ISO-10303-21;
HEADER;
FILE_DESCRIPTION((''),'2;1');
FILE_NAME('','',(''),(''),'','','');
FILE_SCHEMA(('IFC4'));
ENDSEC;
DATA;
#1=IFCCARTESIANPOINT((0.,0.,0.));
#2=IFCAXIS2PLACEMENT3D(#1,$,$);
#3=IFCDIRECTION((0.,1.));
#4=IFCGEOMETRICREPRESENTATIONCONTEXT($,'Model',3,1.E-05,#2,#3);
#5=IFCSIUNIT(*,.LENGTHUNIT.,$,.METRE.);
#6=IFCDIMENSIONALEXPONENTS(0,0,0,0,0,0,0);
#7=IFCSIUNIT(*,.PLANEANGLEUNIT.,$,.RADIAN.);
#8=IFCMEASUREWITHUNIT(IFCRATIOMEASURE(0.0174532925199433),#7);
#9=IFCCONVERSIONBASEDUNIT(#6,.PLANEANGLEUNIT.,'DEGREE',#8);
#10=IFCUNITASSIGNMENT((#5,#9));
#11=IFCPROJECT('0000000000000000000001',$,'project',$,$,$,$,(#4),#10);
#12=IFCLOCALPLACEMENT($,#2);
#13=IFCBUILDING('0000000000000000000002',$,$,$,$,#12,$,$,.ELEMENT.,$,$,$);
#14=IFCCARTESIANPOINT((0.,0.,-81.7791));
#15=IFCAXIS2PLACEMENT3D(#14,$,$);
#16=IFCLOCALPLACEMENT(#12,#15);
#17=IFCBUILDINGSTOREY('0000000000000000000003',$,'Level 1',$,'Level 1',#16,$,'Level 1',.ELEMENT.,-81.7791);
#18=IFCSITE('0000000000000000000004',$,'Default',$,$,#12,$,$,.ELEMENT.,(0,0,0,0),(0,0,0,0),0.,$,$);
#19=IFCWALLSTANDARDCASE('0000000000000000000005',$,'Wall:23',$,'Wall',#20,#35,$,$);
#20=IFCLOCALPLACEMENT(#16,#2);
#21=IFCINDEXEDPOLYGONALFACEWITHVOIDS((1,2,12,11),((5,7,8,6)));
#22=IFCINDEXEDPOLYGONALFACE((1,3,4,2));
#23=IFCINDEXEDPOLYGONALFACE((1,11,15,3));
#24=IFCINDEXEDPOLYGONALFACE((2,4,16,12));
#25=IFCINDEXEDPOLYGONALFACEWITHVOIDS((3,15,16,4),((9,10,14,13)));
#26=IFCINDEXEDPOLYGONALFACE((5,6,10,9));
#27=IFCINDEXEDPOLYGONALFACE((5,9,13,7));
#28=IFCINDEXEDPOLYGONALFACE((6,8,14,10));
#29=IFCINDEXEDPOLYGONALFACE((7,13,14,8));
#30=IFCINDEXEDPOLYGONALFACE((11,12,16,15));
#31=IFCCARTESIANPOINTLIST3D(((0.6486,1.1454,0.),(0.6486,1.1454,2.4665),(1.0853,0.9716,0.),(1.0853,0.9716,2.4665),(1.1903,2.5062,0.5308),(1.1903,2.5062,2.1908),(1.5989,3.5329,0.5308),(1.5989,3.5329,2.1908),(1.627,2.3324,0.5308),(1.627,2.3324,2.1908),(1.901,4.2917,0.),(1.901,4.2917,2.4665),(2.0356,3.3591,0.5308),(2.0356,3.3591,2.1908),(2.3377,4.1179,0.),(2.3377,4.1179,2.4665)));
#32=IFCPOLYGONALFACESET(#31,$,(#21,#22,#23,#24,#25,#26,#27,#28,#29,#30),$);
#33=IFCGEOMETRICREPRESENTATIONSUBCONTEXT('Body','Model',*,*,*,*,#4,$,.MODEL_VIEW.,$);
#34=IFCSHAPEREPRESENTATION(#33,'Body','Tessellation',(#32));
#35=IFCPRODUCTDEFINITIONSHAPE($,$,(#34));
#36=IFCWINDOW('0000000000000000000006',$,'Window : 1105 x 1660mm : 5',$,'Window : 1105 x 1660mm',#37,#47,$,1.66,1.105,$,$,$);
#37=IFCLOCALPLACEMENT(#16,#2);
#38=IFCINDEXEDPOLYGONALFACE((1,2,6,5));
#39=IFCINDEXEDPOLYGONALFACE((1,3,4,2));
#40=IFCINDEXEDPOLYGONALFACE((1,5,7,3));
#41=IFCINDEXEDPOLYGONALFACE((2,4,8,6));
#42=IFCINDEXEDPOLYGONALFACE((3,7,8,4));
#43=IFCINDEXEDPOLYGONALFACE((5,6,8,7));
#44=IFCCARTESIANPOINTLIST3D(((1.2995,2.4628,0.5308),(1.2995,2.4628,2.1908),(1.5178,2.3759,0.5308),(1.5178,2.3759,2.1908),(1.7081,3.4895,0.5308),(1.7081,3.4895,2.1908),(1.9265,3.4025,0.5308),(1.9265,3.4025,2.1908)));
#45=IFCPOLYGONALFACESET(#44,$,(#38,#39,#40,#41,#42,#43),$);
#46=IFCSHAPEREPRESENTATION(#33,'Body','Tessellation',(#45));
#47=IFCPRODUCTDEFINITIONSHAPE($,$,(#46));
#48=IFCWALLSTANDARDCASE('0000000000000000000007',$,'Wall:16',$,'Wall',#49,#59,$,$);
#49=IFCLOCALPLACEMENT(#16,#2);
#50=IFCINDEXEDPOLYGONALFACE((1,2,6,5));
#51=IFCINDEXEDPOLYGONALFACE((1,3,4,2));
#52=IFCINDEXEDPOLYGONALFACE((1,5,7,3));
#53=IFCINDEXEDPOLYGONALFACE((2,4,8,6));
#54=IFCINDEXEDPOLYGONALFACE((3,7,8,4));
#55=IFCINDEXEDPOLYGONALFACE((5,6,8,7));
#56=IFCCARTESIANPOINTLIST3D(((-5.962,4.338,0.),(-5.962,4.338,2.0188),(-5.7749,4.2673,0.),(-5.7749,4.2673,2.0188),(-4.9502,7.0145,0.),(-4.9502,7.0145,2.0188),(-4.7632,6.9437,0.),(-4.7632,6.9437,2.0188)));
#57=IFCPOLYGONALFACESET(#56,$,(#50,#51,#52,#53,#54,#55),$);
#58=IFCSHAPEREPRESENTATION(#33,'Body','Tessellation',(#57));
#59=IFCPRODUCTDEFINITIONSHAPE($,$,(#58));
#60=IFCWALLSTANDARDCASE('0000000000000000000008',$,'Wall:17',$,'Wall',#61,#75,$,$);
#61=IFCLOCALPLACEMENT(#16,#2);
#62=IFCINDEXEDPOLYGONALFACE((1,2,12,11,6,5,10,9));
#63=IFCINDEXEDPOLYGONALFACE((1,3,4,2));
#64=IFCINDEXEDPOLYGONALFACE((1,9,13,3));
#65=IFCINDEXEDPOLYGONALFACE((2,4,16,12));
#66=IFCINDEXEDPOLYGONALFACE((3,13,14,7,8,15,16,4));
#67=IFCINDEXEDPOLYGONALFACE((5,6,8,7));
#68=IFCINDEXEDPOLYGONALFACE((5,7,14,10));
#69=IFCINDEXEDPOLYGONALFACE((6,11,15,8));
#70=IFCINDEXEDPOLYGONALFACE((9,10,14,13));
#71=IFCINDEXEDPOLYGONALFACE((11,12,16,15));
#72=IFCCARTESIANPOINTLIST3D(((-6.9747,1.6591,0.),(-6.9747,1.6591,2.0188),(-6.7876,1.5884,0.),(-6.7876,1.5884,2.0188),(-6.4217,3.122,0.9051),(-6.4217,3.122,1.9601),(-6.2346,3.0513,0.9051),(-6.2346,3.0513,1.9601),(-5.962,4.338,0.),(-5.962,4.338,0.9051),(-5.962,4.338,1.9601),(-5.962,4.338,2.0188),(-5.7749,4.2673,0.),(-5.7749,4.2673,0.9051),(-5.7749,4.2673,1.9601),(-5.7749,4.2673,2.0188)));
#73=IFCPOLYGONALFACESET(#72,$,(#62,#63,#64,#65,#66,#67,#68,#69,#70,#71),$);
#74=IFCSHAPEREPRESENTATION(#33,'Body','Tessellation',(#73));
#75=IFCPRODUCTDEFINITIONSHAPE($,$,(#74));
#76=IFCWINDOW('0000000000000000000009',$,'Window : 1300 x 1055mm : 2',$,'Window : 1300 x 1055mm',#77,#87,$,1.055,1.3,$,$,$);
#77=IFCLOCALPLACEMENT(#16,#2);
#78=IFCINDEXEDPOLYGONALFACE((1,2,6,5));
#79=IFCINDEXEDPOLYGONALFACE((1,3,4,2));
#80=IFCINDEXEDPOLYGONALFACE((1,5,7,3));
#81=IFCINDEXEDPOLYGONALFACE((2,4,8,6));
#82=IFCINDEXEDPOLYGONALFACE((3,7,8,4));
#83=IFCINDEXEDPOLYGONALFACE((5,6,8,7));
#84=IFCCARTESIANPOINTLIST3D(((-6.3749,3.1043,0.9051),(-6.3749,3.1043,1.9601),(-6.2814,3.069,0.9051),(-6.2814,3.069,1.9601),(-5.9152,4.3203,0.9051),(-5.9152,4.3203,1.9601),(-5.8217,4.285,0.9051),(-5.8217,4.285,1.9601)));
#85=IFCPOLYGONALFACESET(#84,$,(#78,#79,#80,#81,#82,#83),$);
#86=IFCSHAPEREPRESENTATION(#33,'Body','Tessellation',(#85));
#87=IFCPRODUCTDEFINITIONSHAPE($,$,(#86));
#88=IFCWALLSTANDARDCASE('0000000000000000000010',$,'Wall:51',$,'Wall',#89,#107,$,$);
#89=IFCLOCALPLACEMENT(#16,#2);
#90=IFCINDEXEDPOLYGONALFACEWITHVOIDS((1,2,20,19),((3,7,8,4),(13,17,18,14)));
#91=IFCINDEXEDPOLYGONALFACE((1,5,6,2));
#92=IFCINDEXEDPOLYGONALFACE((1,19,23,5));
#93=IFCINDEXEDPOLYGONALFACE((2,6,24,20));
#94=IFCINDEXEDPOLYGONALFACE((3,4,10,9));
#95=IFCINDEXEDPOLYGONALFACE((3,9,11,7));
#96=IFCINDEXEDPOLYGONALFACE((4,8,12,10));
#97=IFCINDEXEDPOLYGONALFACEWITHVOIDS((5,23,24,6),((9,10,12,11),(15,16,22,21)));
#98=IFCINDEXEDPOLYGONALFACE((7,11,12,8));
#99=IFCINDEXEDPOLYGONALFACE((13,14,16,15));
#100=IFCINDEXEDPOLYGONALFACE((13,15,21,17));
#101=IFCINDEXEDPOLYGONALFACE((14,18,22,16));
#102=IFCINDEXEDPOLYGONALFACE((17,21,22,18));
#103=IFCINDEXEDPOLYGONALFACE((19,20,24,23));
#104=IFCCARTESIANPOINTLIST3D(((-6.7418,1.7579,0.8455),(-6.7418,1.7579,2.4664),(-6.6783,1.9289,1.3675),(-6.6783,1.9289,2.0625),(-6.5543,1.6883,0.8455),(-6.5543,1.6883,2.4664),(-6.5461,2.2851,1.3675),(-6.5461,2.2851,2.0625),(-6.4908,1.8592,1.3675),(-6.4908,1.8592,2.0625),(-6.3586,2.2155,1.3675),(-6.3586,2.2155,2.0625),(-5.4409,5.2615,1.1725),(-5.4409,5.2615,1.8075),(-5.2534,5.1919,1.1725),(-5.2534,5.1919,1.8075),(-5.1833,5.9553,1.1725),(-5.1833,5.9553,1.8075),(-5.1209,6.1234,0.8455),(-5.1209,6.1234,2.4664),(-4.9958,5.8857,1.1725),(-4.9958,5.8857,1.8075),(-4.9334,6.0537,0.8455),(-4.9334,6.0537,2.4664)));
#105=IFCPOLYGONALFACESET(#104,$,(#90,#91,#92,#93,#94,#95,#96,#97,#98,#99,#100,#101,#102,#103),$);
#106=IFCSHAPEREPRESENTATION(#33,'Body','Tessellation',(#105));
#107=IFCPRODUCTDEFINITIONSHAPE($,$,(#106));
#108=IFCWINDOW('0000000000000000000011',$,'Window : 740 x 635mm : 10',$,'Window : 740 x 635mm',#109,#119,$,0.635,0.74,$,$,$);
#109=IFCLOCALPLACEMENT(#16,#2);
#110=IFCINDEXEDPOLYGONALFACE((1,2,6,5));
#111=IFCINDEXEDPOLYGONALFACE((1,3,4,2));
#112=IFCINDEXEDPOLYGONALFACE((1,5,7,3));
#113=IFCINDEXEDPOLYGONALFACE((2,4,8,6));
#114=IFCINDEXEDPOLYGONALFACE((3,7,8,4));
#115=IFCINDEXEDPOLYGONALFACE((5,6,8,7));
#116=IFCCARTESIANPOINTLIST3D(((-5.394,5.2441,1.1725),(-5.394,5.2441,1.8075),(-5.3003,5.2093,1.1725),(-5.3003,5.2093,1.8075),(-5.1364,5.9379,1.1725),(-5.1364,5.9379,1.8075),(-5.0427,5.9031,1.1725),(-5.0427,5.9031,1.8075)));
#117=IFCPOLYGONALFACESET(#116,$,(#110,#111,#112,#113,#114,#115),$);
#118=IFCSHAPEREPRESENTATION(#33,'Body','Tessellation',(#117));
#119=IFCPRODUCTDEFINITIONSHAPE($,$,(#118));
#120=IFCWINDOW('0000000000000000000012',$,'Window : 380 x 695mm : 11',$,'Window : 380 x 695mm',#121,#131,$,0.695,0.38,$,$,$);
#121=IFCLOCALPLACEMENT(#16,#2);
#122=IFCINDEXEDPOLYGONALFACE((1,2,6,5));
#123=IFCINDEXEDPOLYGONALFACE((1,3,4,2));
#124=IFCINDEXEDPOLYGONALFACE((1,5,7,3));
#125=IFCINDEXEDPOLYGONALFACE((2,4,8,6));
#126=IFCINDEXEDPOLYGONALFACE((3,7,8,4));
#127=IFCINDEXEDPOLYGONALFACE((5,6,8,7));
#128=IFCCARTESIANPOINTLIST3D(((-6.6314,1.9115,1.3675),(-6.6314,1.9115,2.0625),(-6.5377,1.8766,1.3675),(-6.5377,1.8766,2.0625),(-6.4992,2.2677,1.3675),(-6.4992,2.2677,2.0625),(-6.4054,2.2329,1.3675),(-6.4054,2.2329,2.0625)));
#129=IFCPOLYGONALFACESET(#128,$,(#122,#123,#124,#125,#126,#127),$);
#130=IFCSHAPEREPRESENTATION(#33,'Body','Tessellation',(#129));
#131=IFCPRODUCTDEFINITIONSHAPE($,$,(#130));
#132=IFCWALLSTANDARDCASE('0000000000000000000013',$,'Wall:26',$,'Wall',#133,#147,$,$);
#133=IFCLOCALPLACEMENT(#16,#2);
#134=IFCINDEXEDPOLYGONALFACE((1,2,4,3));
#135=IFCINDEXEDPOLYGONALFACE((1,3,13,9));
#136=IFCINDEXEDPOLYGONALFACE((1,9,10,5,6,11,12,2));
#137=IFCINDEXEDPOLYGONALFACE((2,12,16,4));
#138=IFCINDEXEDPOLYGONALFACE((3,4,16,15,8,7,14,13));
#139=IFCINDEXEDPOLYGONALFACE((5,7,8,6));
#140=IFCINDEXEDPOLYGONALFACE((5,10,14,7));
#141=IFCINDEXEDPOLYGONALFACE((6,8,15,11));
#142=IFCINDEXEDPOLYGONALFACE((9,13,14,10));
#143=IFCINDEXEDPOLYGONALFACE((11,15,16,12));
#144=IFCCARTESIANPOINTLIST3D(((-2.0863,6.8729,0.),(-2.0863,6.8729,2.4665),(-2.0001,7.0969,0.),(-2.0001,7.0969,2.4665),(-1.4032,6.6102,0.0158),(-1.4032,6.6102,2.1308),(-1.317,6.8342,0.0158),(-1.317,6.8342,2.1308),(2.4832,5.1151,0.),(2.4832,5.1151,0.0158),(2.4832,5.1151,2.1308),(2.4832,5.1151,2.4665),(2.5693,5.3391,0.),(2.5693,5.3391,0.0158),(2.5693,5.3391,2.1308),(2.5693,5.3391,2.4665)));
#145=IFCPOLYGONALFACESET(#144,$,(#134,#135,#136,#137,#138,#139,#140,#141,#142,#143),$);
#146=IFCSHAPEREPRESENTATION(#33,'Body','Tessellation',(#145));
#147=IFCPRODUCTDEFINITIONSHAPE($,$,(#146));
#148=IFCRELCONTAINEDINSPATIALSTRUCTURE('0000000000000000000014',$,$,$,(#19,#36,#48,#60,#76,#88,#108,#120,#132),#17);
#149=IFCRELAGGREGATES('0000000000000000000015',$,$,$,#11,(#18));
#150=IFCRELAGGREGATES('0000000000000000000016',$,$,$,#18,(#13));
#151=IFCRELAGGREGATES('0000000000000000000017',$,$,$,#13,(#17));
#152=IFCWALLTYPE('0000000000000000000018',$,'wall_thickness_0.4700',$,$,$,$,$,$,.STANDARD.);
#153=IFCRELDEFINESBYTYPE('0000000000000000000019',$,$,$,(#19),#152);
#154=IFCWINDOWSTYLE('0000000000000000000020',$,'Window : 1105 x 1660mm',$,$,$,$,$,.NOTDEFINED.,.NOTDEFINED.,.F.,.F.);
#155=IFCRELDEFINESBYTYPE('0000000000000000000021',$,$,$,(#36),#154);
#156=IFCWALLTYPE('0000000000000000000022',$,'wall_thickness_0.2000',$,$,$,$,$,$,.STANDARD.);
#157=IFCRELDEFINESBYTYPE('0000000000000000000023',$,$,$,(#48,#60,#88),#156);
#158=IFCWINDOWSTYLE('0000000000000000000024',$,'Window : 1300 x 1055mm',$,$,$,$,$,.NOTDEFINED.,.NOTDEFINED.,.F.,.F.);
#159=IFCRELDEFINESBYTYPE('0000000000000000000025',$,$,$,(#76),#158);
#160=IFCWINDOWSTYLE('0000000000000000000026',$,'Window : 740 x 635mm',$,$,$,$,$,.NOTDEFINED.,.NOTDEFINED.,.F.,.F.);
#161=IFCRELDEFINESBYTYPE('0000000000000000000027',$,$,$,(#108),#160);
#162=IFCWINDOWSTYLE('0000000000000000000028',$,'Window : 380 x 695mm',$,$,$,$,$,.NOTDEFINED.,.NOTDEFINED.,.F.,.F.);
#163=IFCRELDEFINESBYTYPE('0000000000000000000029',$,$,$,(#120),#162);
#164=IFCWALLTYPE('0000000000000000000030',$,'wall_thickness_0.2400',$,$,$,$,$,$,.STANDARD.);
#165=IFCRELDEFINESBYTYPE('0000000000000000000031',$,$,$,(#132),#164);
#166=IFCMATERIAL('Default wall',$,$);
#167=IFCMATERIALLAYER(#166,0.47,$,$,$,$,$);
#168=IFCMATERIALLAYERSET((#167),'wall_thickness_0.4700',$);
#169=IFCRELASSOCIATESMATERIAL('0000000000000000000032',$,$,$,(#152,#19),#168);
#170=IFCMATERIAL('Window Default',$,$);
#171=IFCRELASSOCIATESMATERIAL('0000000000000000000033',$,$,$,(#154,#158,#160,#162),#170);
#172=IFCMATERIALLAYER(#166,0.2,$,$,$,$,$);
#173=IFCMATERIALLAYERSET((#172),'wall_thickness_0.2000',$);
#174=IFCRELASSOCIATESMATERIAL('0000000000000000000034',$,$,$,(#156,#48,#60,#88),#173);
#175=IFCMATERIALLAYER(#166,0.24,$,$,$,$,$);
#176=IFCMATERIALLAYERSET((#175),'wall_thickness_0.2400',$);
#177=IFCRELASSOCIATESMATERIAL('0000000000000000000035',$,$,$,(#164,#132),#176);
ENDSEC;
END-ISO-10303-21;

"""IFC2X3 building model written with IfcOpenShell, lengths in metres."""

from ifc_helpers import new_model, entity, si_unit, converted_unit, direction, frame, frame_2d, origin, origin_2d_with_axis, place, context, subcontext, project, spatial, polyline, rectangle, outline, extrude, source, transform, mapped, material, layer, layer_set, layer_usage, type_object, type_shapes, element, fill, save


model = new_model("IFC2X3")

# Units and contexts
model_context = context("Model", 3, precision=1e-05, world=origin(), true_north=direction((0.0, 1.0)))
body_context = subcontext(model_context, "Body", "Model", "MODEL_VIEW")
ifc_project = project(units=[si_unit("LENGTHUNIT", "METRE"), converted_unit("PLANEANGLEUNIT", "DEGREE", entity("IfcRatioMeasure", 0.0174532925199433), si_unit("PLANEANGLEUNIT", "RADIAN"), dimensions=[0, 0, 0, 0, 0, 0, 0])], contexts=[model_context])

# Site, building, storey
placement_1 = place(None, origin())
site = spatial("IfcSite", under=ifc_project, at=placement_1, Name="Default", CompositionType="ELEMENT", RefLatitude=(0, 0, 0, 0), RefLongitude=(0, 0, 0, 0), RefElevation=0.0)
building = spatial("IfcBuilding", under=site, at=placement_1, CompositionType="ELEMENT")
storey_placement = place(placement_1, frame((0.0, 0.0, -81.7791)))
storey = spatial("IfcBuildingStorey", under=building, at=storey_placement, Name="Level 1", ObjectType="Level 1", LongName="Level 1", CompositionType="ELEMENT", Elevation=-81.7791)

# Shared definitions
ifc_material_1 = material(Name="Default wall")

# Shared definitions
ifc_layer_1 = layer(ifc_material_1, 0.47)
ifc_layer_set_1 = layer_set([ifc_layer_1], Name="wall_thickness_0.4700")
ifc_layer_usage_1 = layer_usage(ifc_layer_set_1, "AXIS2", "POSITIVE", -0.235)
wall_type_1 = type_object("IfcWallType", Name="wall_thickness_0.4700", PredefinedType="STANDARD", material=ifc_layer_set_1)

# Wall, opening, window
wall_1_placement = place(storey_placement, frame((2.1193, 4.2048, 0.0), z_axis=(0.0, 0.0, 1.0), x_axis=(-0.36982, -0.929103, 0.0)))
wall_1 = element("IfcWallStandardCase", 1, at=wall_1_placement, inside=storey, type_object=wall_type_1, material=ifc_layer_usage_1, Name="Wall:23", ObjectType="Wall", context=body_context, shape_type="SweptSolid", body=[
    extrude(outline(polyline([(3.3864, -0.235), (3.3864, 0.235), (0.0, 0.235), (0.0, -0.235), (3.3864, -0.235)])), origin(), (0.0, 0.0, 1.0), 2.4665),
])
opening_1_placement = place(wall_1_placement, frame((0.8167, -0.235, 0.5308)))
opening_1 = element("IfcOpeningElement", 2, at=opening_1_placement, cuts=wall_1, ObjectType="Opening", context=body_context, shape_type="SweptSolid", body=[
    extrude(rectangle(XDim=1.105, YDim=1.66, at=frame_2d((0.83, 0.5525), x_axis=(0.0, 1.0))), frame((0.0, 0.0, 0.0), z_axis=(0.0, 1.0, 0.0), x_axis=(0.0, 0.0, 1.0)), (0.0, 0.0, 1.0), 0.47),
])
ifc_material_2 = material(Name="Window Default")
window_style_1 = type_object("IfcWindowStyle", Name="Window : 1105 x 1660mm", ConstructionType="NOTDEFINED", OperationType="NOTDEFINED", ParameterTakesPrecedence=False, Sizeable=False, material=ifc_material_2)
shared_shape_1 = source(origin(), body_context, "Body", "SweptSolid", [
    extrude(rectangle(XDim=0.235, YDim=1.105, at=origin_2d_with_axis()), frame((0.5525, 0.235, 0.0), z_axis=(0.0, 0.0, 1.0), x_axis=(0.0, 1.0, 0.0)), (0.0, 0.0, 1.0), 1.66),
])
type_shapes(window_style_1, [shared_shape_1])
window_1_placement = place(opening_1_placement, origin())
window_1 = element("IfcWindow", 3, at=window_1_placement, inside=storey, type_object=window_style_1, Name="Window : 1105 x 1660mm : 5", ObjectType="Window : 1105 x 1660mm", OverallHeight=1.66, OverallWidth=1.105, context=body_context, shape_type="MappedRepresentation", body=[
    mapped(shared_shape_1, transform((0.0, 0.0, 0.0), scale=1.0)),
])
fill(opening_1, window_1)

# Wall
ifc_layer_2 = layer(ifc_material_1, 0.2)
ifc_layer_set_2 = layer_set([ifc_layer_2], Name="wall_thickness_0.2000")
ifc_layer_usage_2 = layer_usage(ifc_layer_set_2, "AXIS2", "POSITIVE", -0.1)
wall_type_2 = type_object("IfcWallType", Name="wall_thickness_0.2000", PredefinedType="STANDARD", material=ifc_layer_set_2)
wall_2_placement = place(storey_placement, frame((-4.8567, 6.9791, 0.0), z_axis=(0.0, 0.0, 1.0), x_axis=(-0.353606, -0.935394, 0.0)))
element("IfcWallStandardCase", 4, at=wall_2_placement, inside=storey, type_object=wall_type_2, material=ifc_layer_usage_2, Name="Wall:16", ObjectType="Wall", context=body_context, shape_type="SweptSolid", body=[
    extrude(outline(polyline([(2.8613, -0.1), (2.8613, 0.1), (0.0, 0.1), (0.0, -0.1), (2.8613, -0.1)])), origin(), (0.0, 0.0, 1.0), 2.0188),
])

# Wall, opening, window
wall_3_placement = place(storey_placement, frame((-5.8685, 4.3027, 0.0), z_axis=(0.0, 0.0, 1.0), x_axis=(-0.353606, -0.935394, 0.0)))
wall_3 = element("IfcWallStandardCase", 5, at=wall_3_placement, inside=storey, type_object=wall_type_2, material=ifc_layer_usage_2, Name="Wall:17", ObjectType="Wall", context=body_context, shape_type="SweptSolid", body=[
    extrude(outline(polyline([(2.8639, -0.1), (2.8639, 0.1), (0.0, 0.1), (0.0, -0.1), (2.8639, -0.1)])), origin(), (0.0, 0.0, 1.0), 2.0188),
])
opening_2_placement = place(wall_3_placement, frame((0.0, -0.1, 0.9051)))
opening_2 = element("IfcOpeningElement", 6, at=opening_2_placement, cuts=wall_3, ObjectType="Opening", context=body_context, shape_type="SweptSolid", body=[
    extrude(rectangle(XDim=1.3, YDim=1.055, at=frame_2d((0.5275, 0.65), x_axis=(0.0, 1.0))), frame((0.0, 0.0, 0.0), z_axis=(0.0, 1.0, 0.0), x_axis=(0.0, 0.0, 1.0)), (0.0, 0.0, 1.0), 0.2),
])
window_style_2 = type_object("IfcWindowStyle", Name="Window : 1300 x 1055mm", ConstructionType="NOTDEFINED", OperationType="NOTDEFINED", ParameterTakesPrecedence=False, Sizeable=False, material=ifc_material_2)
shared_shape_2 = source(origin(), body_context, "Body", "SweptSolid", [
    extrude(rectangle(XDim=0.1, YDim=1.3, at=origin_2d_with_axis()), frame((0.65, 0.1, 0.0), z_axis=(0.0, 0.0, 1.0), x_axis=(0.0, 1.0, 0.0)), (0.0, 0.0, 1.0), 1.055),
])
type_shapes(window_style_2, [shared_shape_2])
window_2_placement = place(opening_2_placement, origin())
window_2 = element("IfcWindow", 7, at=window_2_placement, inside=storey, type_object=window_style_2, Name="Window : 1300 x 1055mm : 2", ObjectType="Window : 1300 x 1055mm", OverallHeight=1.055, OverallWidth=1.3, context=body_context, shape_type="MappedRepresentation", body=[
    mapped(shared_shape_2, transform((0.0, 0.0, 0.0), scale=1.0)),
])
fill(opening_2, window_2)

# Wall, openings, windows
placement_2 = place(placement_1, frame((0.0, 0.0, -80.9336)))
wall_4_placement = place(placement_2, frame((-5.0272, 6.0886, 0.0), z_axis=(0.0, 0.0, 1.0), x_axis=(-0.348079, -0.937465, 0.0)))
wall_4 = element("IfcWallStandardCase", 8, at=wall_4_placement, inside=storey, type_object=wall_type_2, material=ifc_layer_usage_2, Name="Wall:51", ObjectType="Wall", context=body_context, shape_type="SweptSolid", body=[
    extrude(outline(polyline([(4.6566, -0.1), (4.6566, 0.1), (0.0, 0.1), (0.0, -0.1), (4.6566, -0.1)])), origin(), (0.0, 0.0, 1.0), 1.6209),
])
opening_3_placement = place(wall_4_placement, frame((0.1793, -0.1, 0.327)))
opening_3 = element("IfcOpeningElement", 9, at=opening_3_placement, cuts=wall_4, ObjectType="Opening", context=body_context, shape_type="SweptSolid", body=[
    extrude(rectangle(XDim=0.74, YDim=0.635, at=frame_2d((0.3175, 0.37), x_axis=(0.0, 1.0))), frame((0.0, 0.0, 0.0), z_axis=(0.0, 1.0, 0.0), x_axis=(0.0, 0.0, 1.0)), (0.0, 0.0, 1.0), 0.2),
])
opening_4_placement = place(wall_4_placement, frame((4.0943, -0.1, 0.522)))
opening_4 = element("IfcOpeningElement", 10, at=opening_4_placement, cuts=wall_4, ObjectType="Opening", context=body_context, shape_type="SweptSolid", body=[
    extrude(rectangle(XDim=0.38, YDim=0.695, at=frame_2d((0.3475, 0.19), x_axis=(0.0, 1.0))), frame((0.0, 0.0, 0.0), z_axis=(0.0, 1.0, 0.0), x_axis=(0.0, 0.0, 1.0)), (0.0, 0.0, 1.0), 0.2),
])
window_style_3 = type_object("IfcWindowStyle", Name="Window : 740 x 635mm", ConstructionType="NOTDEFINED", OperationType="NOTDEFINED", ParameterTakesPrecedence=False, Sizeable=False, material=ifc_material_2)
shared_shape_3 = source(origin(), body_context, "Body", "SweptSolid", [
    extrude(rectangle(XDim=0.1, YDim=0.74, at=origin_2d_with_axis()), frame((0.37, 0.1, 0.0), z_axis=(0.0, 0.0, 1.0), x_axis=(0.0, 1.0, 0.0)), (0.0, 0.0, 1.0), 0.635),
])
type_shapes(window_style_3, [shared_shape_3])
window_3_placement = place(opening_3_placement, origin())
window_3 = element("IfcWindow", 11, at=window_3_placement, inside=storey, type_object=window_style_3, Name="Window : 740 x 635mm : 10", ObjectType="Window : 740 x 635mm", OverallHeight=0.635, OverallWidth=0.74, context=body_context, shape_type="MappedRepresentation", body=[
    mapped(shared_shape_3, transform((0.0, 0.0, 0.0), scale=1.0)),
])
fill(opening_3, window_3)
window_style_4 = type_object("IfcWindowStyle", Name="Window : 380 x 695mm", ConstructionType="NOTDEFINED", OperationType="NOTDEFINED", ParameterTakesPrecedence=False, Sizeable=False, material=ifc_material_2)
shared_shape_4 = source(origin(), body_context, "Body", "SweptSolid", [
    extrude(rectangle(XDim=0.1, YDim=0.38, at=origin_2d_with_axis()), frame((0.19, 0.1, 0.0), z_axis=(0.0, 0.0, 1.0), x_axis=(0.0, 1.0, 0.0)), (0.0, 0.0, 1.0), 0.695),
])
type_shapes(window_style_4, [shared_shape_4])
window_4_placement = place(opening_4_placement, origin())
window_4 = element("IfcWindow", 12, at=window_4_placement, inside=storey, type_object=window_style_4, Name="Window : 380 x 695mm : 11", ObjectType="Window : 380 x 695mm", OverallHeight=0.695, OverallWidth=0.38, context=body_context, shape_type="MappedRepresentation", body=[
    mapped(shared_shape_4, transform((0.0, 0.0, 0.0), scale=1.0)),
])
fill(opening_4, window_4)

# Wall, opening
ifc_layer_3 = layer(ifc_material_1, 0.24)
ifc_layer_set_3 = layer_set([ifc_layer_3], Name="wall_thickness_0.2400")
ifc_layer_usage_3 = layer_usage(ifc_layer_set_3, "AXIS2", "POSITIVE", -0.12)
wall_type_3 = type_object("IfcWallType", Name="wall_thickness_0.2400", PredefinedType="STANDARD", material=ifc_layer_set_3)
wall_5_placement = place(storey_placement, frame((-2.0432, 6.9849, 0.0), z_axis=(0.0, 0.0, 1.0), x_axis=(0.933323, -0.359038, 0.0)))
wall_5 = element("IfcWallStandardCase", 13, at=wall_5_placement, inside=storey, type_object=wall_type_3, material=ifc_layer_usage_3, Name="Wall:26", ObjectType="Wall", context=body_context, shape_type="SweptSolid", body=[
    extrude(outline(polyline([(4.8959, -0.12), (4.8959, 0.12), (0.0, 0.12), (0.0, -0.12), (4.8959, -0.12)])), origin(), (0.0, 0.0, 1.0), 2.4665),
])
opening_5_placement = place(wall_5_placement, frame((0.7319, -0.12, 0.0158)))
element("IfcOpeningElement", 14, at=opening_5_placement, cuts=wall_5, ObjectType="Opening", context=body_context, shape_type="SweptSolid", body=[
    extrude(rectangle(XDim=4.2, YDim=2.115, at=frame_2d((1.0575, 2.1), x_axis=(0.0, 1.0))), frame((0.0, 0.0, 0.0), z_axis=(0.0, 1.0, 0.0), x_axis=(0.0, 0.0, 1.0)), (0.0, 0.0, 1.0), 0.24),
])

save(model, "model.ifc")
